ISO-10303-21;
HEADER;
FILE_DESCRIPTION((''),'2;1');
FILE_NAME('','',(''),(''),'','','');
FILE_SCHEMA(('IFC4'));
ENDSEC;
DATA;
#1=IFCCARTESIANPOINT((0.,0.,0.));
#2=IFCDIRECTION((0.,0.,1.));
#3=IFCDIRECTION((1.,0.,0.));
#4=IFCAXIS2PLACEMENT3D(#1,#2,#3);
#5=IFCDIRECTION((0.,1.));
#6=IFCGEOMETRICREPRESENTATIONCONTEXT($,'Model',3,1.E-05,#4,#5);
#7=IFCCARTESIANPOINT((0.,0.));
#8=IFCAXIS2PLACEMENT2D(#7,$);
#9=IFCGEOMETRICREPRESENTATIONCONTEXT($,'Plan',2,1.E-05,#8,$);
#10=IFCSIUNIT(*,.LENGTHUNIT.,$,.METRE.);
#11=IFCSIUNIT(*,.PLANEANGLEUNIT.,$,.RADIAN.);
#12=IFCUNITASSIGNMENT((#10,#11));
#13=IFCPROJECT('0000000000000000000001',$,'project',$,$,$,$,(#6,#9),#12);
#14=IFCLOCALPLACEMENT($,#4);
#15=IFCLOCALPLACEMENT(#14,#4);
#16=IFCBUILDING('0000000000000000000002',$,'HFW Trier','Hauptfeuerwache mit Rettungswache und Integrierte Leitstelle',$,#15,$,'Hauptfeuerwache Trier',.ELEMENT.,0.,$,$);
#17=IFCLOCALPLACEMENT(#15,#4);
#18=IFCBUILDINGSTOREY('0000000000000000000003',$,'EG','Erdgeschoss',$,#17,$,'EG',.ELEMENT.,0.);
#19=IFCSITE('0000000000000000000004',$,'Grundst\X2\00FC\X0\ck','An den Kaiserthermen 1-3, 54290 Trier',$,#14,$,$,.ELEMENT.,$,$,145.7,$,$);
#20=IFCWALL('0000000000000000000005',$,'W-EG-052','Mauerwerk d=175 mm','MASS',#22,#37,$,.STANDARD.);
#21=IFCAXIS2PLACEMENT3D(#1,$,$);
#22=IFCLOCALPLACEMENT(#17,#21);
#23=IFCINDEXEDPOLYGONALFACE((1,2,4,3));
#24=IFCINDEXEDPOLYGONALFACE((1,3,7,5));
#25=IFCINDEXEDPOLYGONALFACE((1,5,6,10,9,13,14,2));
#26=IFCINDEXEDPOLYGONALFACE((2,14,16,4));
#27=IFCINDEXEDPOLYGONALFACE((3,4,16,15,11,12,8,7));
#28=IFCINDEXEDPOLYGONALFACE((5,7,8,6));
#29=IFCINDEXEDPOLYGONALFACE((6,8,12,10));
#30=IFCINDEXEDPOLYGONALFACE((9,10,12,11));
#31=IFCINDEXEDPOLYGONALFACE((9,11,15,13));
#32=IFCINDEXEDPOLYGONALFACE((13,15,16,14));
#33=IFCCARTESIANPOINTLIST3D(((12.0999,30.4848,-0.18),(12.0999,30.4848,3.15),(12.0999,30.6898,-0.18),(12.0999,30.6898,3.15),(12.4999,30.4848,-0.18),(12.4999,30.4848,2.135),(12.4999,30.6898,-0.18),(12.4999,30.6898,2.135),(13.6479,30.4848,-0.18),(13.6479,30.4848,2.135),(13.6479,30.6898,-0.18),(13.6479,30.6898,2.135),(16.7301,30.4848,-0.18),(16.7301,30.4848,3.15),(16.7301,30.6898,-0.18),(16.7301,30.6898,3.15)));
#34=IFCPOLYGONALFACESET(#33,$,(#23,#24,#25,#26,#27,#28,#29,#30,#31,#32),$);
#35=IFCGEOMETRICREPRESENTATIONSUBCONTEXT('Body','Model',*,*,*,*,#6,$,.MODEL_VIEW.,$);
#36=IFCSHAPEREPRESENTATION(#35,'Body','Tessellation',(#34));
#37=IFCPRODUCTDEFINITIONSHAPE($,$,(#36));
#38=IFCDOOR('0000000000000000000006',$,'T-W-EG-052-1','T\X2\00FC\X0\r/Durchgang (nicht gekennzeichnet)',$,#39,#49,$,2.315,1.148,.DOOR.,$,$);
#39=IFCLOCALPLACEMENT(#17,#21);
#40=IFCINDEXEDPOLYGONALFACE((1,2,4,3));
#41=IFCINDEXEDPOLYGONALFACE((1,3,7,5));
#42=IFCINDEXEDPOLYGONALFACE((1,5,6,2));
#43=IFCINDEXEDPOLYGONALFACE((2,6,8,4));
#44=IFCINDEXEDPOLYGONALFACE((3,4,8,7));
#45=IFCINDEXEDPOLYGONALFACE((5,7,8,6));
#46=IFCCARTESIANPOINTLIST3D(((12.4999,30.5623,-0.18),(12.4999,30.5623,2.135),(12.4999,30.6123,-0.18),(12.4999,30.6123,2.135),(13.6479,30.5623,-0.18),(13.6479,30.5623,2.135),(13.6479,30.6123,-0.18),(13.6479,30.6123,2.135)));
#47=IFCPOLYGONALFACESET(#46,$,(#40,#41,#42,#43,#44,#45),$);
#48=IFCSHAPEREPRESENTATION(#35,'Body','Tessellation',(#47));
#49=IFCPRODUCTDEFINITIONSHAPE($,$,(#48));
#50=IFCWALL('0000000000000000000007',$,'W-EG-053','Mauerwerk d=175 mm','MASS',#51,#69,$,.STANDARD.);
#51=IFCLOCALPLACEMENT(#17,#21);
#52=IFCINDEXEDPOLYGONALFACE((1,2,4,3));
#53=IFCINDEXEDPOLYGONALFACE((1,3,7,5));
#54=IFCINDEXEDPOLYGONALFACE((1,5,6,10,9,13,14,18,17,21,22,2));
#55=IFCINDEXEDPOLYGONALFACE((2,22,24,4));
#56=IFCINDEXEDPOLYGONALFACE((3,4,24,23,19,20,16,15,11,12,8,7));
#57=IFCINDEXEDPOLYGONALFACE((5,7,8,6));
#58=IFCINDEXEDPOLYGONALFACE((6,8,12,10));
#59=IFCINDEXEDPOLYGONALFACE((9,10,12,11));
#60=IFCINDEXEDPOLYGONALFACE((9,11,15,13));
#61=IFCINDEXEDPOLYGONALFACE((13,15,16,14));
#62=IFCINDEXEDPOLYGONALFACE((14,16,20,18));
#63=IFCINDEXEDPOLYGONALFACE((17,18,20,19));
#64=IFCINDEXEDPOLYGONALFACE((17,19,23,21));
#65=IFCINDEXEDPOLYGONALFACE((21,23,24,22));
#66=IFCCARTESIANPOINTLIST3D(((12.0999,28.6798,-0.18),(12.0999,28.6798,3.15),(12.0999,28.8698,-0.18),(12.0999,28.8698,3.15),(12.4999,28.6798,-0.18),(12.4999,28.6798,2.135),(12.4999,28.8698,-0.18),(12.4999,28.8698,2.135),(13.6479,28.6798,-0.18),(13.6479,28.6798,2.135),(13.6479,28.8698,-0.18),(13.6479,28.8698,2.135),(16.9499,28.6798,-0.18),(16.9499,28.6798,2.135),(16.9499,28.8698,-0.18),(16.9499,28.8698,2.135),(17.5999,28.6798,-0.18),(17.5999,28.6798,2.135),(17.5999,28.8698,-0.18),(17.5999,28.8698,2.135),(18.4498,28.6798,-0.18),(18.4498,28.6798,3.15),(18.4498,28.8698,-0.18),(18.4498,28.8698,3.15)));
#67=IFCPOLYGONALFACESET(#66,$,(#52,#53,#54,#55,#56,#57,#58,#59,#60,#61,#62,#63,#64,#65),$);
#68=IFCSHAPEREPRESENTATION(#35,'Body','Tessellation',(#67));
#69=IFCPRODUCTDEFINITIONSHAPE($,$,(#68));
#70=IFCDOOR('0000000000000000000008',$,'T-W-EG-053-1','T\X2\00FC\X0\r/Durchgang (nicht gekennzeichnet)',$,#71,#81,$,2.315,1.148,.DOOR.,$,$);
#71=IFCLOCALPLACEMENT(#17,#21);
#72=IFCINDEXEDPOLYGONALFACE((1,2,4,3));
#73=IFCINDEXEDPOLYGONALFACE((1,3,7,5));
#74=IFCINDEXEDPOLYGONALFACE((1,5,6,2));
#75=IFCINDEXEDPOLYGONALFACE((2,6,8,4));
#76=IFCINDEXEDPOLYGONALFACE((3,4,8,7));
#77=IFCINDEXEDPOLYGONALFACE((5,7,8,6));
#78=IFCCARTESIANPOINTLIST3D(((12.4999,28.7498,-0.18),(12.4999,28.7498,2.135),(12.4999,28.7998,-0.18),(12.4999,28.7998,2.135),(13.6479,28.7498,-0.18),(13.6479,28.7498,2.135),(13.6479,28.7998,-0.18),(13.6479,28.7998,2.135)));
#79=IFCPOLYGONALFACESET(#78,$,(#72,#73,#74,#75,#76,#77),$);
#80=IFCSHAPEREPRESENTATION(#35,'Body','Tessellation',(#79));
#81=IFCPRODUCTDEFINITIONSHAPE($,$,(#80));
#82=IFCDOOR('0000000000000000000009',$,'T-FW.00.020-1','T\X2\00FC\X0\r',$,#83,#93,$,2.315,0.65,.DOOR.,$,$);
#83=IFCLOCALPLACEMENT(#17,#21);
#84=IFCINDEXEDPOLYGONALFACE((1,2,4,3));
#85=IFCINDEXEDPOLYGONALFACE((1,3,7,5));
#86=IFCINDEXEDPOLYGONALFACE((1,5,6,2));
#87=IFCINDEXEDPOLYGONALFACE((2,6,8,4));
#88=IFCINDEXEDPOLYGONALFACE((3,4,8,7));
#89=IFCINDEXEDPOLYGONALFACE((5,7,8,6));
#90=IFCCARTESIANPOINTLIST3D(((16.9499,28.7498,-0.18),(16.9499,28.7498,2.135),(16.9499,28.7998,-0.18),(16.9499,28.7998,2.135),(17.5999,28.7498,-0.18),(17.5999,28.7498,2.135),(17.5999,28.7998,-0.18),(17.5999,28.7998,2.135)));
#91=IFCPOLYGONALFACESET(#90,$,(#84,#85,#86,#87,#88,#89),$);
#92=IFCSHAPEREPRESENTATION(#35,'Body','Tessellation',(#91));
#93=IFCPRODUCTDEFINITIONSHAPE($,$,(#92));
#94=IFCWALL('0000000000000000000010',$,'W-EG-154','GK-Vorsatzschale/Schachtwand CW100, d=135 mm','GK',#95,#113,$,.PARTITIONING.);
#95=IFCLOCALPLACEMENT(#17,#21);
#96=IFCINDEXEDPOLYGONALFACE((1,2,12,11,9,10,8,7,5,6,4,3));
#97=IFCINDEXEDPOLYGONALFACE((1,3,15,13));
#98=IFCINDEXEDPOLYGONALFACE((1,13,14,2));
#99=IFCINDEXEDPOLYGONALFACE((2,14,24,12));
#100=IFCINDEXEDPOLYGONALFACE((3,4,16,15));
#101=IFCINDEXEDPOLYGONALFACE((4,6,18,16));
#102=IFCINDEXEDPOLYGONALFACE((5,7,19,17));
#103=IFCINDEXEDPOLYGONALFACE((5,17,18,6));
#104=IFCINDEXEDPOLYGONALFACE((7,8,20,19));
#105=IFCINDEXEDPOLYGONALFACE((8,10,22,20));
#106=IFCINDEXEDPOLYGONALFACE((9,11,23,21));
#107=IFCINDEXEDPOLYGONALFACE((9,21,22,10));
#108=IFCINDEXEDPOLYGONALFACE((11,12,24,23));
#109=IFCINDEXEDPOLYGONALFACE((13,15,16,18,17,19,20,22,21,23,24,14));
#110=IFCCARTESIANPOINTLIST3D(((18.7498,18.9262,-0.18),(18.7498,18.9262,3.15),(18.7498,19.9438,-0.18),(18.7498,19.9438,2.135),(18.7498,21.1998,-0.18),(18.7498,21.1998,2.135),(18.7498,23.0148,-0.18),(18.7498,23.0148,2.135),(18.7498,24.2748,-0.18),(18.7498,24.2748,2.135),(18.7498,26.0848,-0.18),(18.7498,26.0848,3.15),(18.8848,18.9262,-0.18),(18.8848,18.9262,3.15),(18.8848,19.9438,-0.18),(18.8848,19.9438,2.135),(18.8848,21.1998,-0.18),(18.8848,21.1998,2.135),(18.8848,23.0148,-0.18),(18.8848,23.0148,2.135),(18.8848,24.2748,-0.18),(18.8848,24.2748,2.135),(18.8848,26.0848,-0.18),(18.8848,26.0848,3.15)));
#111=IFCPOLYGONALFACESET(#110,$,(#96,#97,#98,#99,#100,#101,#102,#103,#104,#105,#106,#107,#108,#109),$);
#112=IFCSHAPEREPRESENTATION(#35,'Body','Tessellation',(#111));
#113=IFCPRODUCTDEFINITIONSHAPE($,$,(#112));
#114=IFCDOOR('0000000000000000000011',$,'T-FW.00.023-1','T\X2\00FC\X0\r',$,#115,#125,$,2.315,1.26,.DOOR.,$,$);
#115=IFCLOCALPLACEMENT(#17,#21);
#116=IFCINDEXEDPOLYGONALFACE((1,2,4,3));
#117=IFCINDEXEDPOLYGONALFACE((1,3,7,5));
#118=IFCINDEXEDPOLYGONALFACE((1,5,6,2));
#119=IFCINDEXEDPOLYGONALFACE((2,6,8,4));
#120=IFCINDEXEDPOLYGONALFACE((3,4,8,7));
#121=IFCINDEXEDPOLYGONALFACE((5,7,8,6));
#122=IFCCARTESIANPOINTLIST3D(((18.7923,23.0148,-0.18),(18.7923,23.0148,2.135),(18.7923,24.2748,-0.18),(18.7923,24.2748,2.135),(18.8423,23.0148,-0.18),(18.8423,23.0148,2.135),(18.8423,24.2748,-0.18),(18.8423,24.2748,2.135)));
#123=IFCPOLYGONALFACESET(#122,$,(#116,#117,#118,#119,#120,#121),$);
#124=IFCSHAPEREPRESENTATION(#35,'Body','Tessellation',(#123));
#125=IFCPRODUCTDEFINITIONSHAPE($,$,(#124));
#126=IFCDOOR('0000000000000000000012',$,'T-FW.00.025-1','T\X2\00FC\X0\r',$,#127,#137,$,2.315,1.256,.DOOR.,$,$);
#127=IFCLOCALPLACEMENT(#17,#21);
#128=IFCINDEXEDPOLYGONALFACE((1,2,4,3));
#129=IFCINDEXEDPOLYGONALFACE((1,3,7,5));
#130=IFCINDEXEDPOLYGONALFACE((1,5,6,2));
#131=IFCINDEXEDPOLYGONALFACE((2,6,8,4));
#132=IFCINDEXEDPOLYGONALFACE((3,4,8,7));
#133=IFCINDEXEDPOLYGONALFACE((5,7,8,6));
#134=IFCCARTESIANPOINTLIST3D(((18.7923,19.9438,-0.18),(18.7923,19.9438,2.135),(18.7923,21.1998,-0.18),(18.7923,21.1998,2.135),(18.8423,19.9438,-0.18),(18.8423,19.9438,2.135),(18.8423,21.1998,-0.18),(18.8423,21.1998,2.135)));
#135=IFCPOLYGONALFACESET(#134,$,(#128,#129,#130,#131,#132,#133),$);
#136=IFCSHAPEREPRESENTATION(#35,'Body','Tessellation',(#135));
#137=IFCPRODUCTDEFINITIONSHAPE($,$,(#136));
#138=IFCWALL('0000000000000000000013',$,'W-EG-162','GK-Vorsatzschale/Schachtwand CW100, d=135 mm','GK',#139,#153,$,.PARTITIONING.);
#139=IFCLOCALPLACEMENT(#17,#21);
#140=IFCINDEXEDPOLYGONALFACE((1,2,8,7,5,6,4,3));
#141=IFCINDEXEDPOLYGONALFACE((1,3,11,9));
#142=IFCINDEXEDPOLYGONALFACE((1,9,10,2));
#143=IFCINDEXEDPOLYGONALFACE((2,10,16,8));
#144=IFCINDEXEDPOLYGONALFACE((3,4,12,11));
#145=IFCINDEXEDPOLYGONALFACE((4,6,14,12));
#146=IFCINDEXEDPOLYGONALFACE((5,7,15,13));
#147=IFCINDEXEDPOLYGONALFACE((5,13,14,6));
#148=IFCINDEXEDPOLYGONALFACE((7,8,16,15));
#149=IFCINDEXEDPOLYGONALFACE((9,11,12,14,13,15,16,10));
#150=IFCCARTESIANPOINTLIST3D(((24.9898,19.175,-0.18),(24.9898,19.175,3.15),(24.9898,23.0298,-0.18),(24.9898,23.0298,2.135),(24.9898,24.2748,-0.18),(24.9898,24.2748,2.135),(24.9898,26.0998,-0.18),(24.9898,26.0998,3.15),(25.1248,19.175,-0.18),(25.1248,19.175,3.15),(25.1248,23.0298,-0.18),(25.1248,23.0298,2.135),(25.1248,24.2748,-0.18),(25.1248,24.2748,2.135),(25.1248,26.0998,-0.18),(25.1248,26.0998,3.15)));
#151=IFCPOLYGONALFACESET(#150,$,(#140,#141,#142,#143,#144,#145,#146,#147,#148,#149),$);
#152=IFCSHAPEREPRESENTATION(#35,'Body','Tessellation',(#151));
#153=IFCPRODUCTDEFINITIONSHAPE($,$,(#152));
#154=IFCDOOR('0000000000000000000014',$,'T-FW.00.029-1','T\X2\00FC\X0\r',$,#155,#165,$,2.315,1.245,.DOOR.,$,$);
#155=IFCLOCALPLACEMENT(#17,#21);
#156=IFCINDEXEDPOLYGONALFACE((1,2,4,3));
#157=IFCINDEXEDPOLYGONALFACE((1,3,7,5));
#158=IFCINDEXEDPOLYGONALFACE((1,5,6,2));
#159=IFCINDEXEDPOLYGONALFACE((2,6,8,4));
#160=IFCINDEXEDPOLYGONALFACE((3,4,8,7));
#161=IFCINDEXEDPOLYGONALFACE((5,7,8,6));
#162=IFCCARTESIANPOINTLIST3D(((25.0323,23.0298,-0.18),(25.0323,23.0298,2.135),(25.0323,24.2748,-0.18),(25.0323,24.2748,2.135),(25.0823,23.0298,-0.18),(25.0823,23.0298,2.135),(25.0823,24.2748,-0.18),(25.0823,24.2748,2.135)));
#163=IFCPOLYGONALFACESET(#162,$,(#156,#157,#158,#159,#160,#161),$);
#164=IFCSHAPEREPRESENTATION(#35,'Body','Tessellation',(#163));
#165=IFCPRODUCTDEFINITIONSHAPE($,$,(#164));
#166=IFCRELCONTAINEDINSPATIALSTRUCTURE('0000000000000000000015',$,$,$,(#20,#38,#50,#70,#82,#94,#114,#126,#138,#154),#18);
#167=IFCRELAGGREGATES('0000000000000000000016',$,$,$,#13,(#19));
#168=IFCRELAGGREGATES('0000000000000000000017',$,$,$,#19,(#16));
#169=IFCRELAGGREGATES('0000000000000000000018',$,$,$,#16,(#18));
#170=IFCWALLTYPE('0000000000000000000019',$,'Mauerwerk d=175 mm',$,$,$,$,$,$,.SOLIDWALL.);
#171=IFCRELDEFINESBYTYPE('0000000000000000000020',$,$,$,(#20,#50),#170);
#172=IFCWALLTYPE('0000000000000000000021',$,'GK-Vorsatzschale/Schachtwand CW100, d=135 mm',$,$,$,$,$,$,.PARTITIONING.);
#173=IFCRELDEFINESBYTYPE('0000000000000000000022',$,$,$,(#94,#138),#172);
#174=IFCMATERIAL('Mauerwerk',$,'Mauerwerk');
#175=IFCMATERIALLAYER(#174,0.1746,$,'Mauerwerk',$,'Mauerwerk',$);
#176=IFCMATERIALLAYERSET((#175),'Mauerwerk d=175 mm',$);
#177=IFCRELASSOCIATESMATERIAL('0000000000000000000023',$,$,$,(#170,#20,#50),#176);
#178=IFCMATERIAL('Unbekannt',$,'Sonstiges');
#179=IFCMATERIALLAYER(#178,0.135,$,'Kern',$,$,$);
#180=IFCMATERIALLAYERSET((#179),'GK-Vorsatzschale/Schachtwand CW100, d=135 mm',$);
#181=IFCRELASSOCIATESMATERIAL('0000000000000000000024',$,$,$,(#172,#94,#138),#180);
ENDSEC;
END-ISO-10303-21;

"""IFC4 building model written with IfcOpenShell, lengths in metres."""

from ifc_helpers import new_model, si_unit, direction, frame, frame_2d, origin_with_axes, origin_2d, place, context, subcontext, project, spatial, rectangle, extrude, material, layer, layer_set, layer_usage, type_object, element, fill, save


model = new_model("IFC4")

# Units and contexts
model_context = context("Model", 3, precision=1e-05, world=origin_with_axes(), true_north=direction((0.0, 1.0)))
plan_context = context("Plan", 2, precision=1e-05, world=origin_2d())
body_context = subcontext(model_context, "Body", "Model", "MODEL_VIEW")
ifc_project = project(units=[si_unit("LENGTHUNIT", "METRE"), si_unit("PLANEANGLEUNIT", "RADIAN")], contexts=[model_context, plan_context])

# Site, building, storey
site_placement = place(None, origin_with_axes())
site = spatial("IfcSite", under=ifc_project, at=site_placement, Name="Grundstück", Description="An den Kaiserthermen 1-3, 54290 Trier", CompositionType="ELEMENT", RefElevation=145.7)
building_placement = place(site_placement, origin_with_axes())
building = spatial("IfcBuilding", under=site, at=building_placement, Name="HFW Trier", Description="Hauptfeuerwache mit Rettungswache und Integrierte Leitstelle", LongName="Hauptfeuerwache Trier", CompositionType="ELEMENT", ElevationOfRefHeight=0.0)
storey_placement = place(building_placement, origin_with_axes())
storey = spatial("IfcBuildingStorey", under=building, at=storey_placement, Name="EG", Description="Erdgeschoss", LongName="EG", CompositionType="ELEMENT", Elevation=0.0)

# Wall, opening, door
ifc_material_1 = material(Name="Mauerwerk", Category="Mauerwerk")
ifc_layer_1 = layer(ifc_material_1, 0.1746, Name="Mauerwerk", Category="Mauerwerk")
ifc_layer_set_1 = layer_set([ifc_layer_1], Name="Mauerwerk d=175 mm")
ifc_layer_usage_1 = layer_usage(ifc_layer_set_1, "AXIS2", "POSITIVE", -0.1025)
wall_type_1 = type_object("IfcWallType", Name="Mauerwerk d=175 mm", PredefinedType="SOLIDWALL", material=ifc_layer_set_1)
wall_1_placement = place(storey_placement, frame((12.0999, 30.5873, -0.18), z_axis=(0.0, 0.0, 1.0), x_axis=(1.0, 0.0, 0.0)))
wall_1 = element("IfcWall", 1, at=wall_1_placement, inside=storey, type_object=wall_type_1, material=ifc_layer_usage_1, Name="W-EG-052", Description="Mauerwerk d=175 mm", ObjectType="MASS", PredefinedType="STANDARD", context=body_context, shape_type="SweptSolid", body=[
    extrude(rectangle(XDim=4.6302, YDim=0.205, at=frame_2d((2.3151, 0.0))), origin_with_axes(), (0.0, 0.0, 1.0), 3.33),
])
opening_1_placement = place(wall_1_placement, frame((0.4, 0.0, 0.0), z_axis=(0.0, 0.0, 1.0), x_axis=(1.0, 0.0, 0.0)))
opening_1 = element("IfcOpeningElement", 2, at=opening_1_placement, cuts=wall_1, PredefinedType="OPENING", context=body_context, shape_type="SweptSolid", body=[
    extrude(rectangle(XDim=1.148, YDim=0.305, at=frame_2d((0.574, 0.0))), origin_with_axes(), (0.0, 0.0, 1.0), 2.315),
])
door_1_placement = place(wall_1_placement, frame((0.4, 0.0, 0.0), z_axis=(0.0, 0.0, 1.0), x_axis=(1.0, 0.0, 0.0)))
door_1 = element("IfcDoor", 3, at=door_1_placement, inside=storey, Name="T-W-EG-052-1", Description="Tür/Durchgang (nicht gekennzeichnet)", OverallHeight=2.315, OverallWidth=1.148, PredefinedType="DOOR", context=body_context, shape_type="SweptSolid", body=[
    extrude(rectangle(XDim=1.148, YDim=0.05, at=frame_2d((0.574, 0.0))), origin_with_axes(), (0.0, 0.0, 1.0), 2.315),
])
fill(opening_1, door_1)

# Walls, openings, doors
ifc_layer_usage_2 = layer_usage(ifc_layer_set_1, "AXIS2", "POSITIVE", -0.095)
wall_2_placement = place(storey_placement, frame((12.0999, 28.7748, -0.18), z_axis=(0.0, 0.0, 1.0), x_axis=(1.0, 0.0, 0.0)))
wall_2 = element("IfcWall", 4, at=wall_2_placement, inside=storey, type_object=wall_type_1, material=ifc_layer_usage_2, Name="W-EG-053", Description="Mauerwerk d=175 mm", ObjectType="MASS", PredefinedType="STANDARD", context=body_context, shape_type="SweptSolid", body=[
    extrude(rectangle(XDim=6.3499, YDim=0.19, at=frame_2d((3.1749, 0.0))), origin_with_axes(), (0.0, 0.0, 1.0), 3.33),
])
opening_2_placement = place(wall_2_placement, frame((0.4, 0.0, 0.0), z_axis=(0.0, 0.0, 1.0), x_axis=(1.0, 0.0, 0.0)))
opening_2 = element("IfcOpeningElement", 5, at=opening_2_placement, cuts=wall_2, PredefinedType="OPENING", context=body_context, shape_type="SweptSolid", body=[
    extrude(rectangle(XDim=1.148, YDim=0.29, at=frame_2d((0.574, 0.0))), origin_with_axes(), (0.0, 0.0, 1.0), 2.315),
])
opening_3_placement = place(wall_2_placement, frame((4.85, 0.0, 0.0), z_axis=(0.0, 0.0, 1.0), x_axis=(1.0, 0.0, 0.0)))
opening_3 = element("IfcOpeningElement", 6, at=opening_3_placement, cuts=wall_2, PredefinedType="OPENING", context=body_context, shape_type="SweptSolid", body=[
    extrude(rectangle(XDim=0.65, YDim=0.29, at=frame_2d((0.325, 0.0))), origin_with_axes(), (0.0, 0.0, 1.0), 2.315),
])
door_2_placement = place(wall_2_placement, frame((0.4, 0.0, 0.0), z_axis=(0.0, 0.0, 1.0), x_axis=(1.0, 0.0, 0.0)))
door_2 = element("IfcDoor", 7, at=door_2_placement, inside=storey, Name="T-W-EG-053-1", Description="Tür/Durchgang (nicht gekennzeichnet)", OverallHeight=2.315, OverallWidth=1.148, PredefinedType="DOOR", context=body_context, shape_type="SweptSolid", body=[
    extrude(rectangle(XDim=1.148, YDim=0.05, at=frame_2d((0.574, 0.0))), origin_with_axes(), (0.0, 0.0, 1.0), 2.315),
])
fill(opening_2, door_2)
door_3_placement = place(wall_2_placement, frame((4.85, 0.0, 0.0), z_axis=(0.0, 0.0, 1.0), x_axis=(1.0, 0.0, 0.0)))
door_3 = element("IfcDoor", 8, at=door_3_placement, inside=storey, Name="T-FW.00.020-1", Description="Tür", OverallHeight=2.315, OverallWidth=0.65, PredefinedType="DOOR", context=body_context, shape_type="SweptSolid", body=[
    extrude(rectangle(XDim=0.65, YDim=0.05, at=frame_2d((0.325, 0.0))), origin_with_axes(), (0.0, 0.0, 1.0), 2.315),
])
fill(opening_3, door_3)
ifc_material_2 = material(Name="Unbekannt", Category="Sonstiges")
ifc_layer_2 = layer(ifc_material_2, 0.135, Name="Kern")
ifc_layer_set_2 = layer_set([ifc_layer_2], Name="GK-Vorsatzschale/Schachtwand CW100, d=135 mm")
ifc_layer_usage_3 = layer_usage(ifc_layer_set_2, "AXIS2", "POSITIVE", -0.0675)
wall_type_2 = type_object("IfcWallType", Name="GK-Vorsatzschale/Schachtwand CW100, d=135 mm", PredefinedType="PARTITIONING", material=ifc_layer_set_2)
wall_3_placement = place(storey_placement, frame((18.8173, 26.0848, -0.18), z_axis=(0.0, 0.0, 1.0), x_axis=(0.0, -1.0, 0.0)))
wall_3 = element("IfcWall", 9, at=wall_3_placement, inside=storey, type_object=wall_type_2, material=ifc_layer_usage_3, Name="W-EG-154", Description="GK-Vorsatzschale/Schachtwand CW100, d=135 mm", ObjectType="GK", PredefinedType="PARTITIONING", context=body_context, shape_type="SweptSolid", body=[
    extrude(rectangle(XDim=7.1586, YDim=0.135, at=frame_2d((3.5793, 0.0))), origin_with_axes(), (0.0, 0.0, 1.0), 3.33),
])
opening_4_placement = place(wall_3_placement, frame((1.81, 0.0, 0.0), z_axis=(0.0, 0.0, 1.0), x_axis=(1.0, 0.0, 0.0)))
opening_4 = element("IfcOpeningElement", 10, at=opening_4_placement, cuts=wall_3, PredefinedType="OPENING", context=body_context, shape_type="SweptSolid", body=[
    extrude(rectangle(XDim=1.26, YDim=0.235, at=frame_2d((0.63, 0.0))), origin_with_axes(), (0.0, 0.0, 1.0), 2.315),
])
opening_5_placement = place(wall_3_placement, frame((4.885, 0.0, 0.0), z_axis=(0.0, 0.0, 1.0), x_axis=(1.0, 0.0, 0.0)))
opening_5 = element("IfcOpeningElement", 11, at=opening_5_placement, cuts=wall_3, PredefinedType="OPENING", context=body_context, shape_type="SweptSolid", body=[
    extrude(rectangle(XDim=1.256, YDim=0.235, at=frame_2d((0.628, 0.0))), origin_with_axes(), (0.0, 0.0, 1.0), 2.315),
])
door_4_placement = place(wall_3_placement, frame((1.81, 0.0, 0.0), z_axis=(0.0, 0.0, 1.0), x_axis=(1.0, 0.0, 0.0)))
door_4 = element("IfcDoor", 12, at=door_4_placement, inside=storey, Name="T-FW.00.023-1", Description="Tür", OverallHeight=2.315, OverallWidth=1.26, PredefinedType="DOOR", context=body_context, shape_type="SweptSolid", body=[
    extrude(rectangle(XDim=1.26, YDim=0.05, at=frame_2d((0.63, 0.0))), origin_with_axes(), (0.0, 0.0, 1.0), 2.315),
])
fill(opening_4, door_4)
door_5_placement = place(wall_3_placement, frame((4.885, 0.0, 0.0), z_axis=(0.0, 0.0, 1.0), x_axis=(1.0, 0.0, 0.0)))
door_5 = element("IfcDoor", 13, at=door_5_placement, inside=storey, Name="T-FW.00.025-1", Description="Tür", OverallHeight=2.315, OverallWidth=1.256, PredefinedType="DOOR", context=body_context, shape_type="SweptSolid", body=[
    extrude(rectangle(XDim=1.256, YDim=0.05, at=frame_2d((0.628, 0.0))), origin_with_axes(), (0.0, 0.0, 1.0), 2.315),
])
fill(opening_5, door_5)

# Wall, opening, door
ifc_layer_usage_4 = layer_usage(ifc_layer_set_2, "AXIS2", "POSITIVE", -0.0675)
wall_4_placement = place(storey_placement, frame((25.0573, 26.0998, -0.18), z_axis=(0.0, 0.0, 1.0), x_axis=(0.0, -1.0, 0.0)))
wall_4 = element("IfcWall", 14, at=wall_4_placement, inside=storey, type_object=wall_type_2, material=ifc_layer_usage_4, Name="W-EG-162", Description="GK-Vorsatzschale/Schachtwand CW100, d=135 mm", ObjectType="GK", PredefinedType="PARTITIONING", context=body_context, shape_type="SweptSolid", body=[
    extrude(rectangle(XDim=6.9248, YDim=0.135, at=frame_2d((3.4624, 0.0))), origin_with_axes(), (0.0, 0.0, 1.0), 3.33),
])
opening_6_placement = place(wall_4_placement, frame((1.825, 0.0, 0.0), z_axis=(0.0, 0.0, 1.0), x_axis=(1.0, 0.0, 0.0)))
opening_6 = element("IfcOpeningElement", 15, at=opening_6_placement, cuts=wall_4, PredefinedType="OPENING", context=body_context, shape_type="SweptSolid", body=[
    extrude(rectangle(XDim=1.245, YDim=0.235, at=frame_2d((0.6225, 0.0))), origin_with_axes(), (0.0, 0.0, 1.0), 2.315),
])
door_6_placement = place(wall_4_placement, frame((1.825, 0.0, 0.0), z_axis=(0.0, 0.0, 1.0), x_axis=(1.0, 0.0, 0.0)))
door_6 = element("IfcDoor", 16, at=door_6_placement, inside=storey, Name="T-FW.00.029-1", Description="Tür", OverallHeight=2.315, OverallWidth=1.245, PredefinedType="DOOR", context=body_context, shape_type="SweptSolid", body=[
    extrude(rectangle(XDim=1.245, YDim=0.05, at=frame_2d((0.6225, 0.0))), origin_with_axes(), (0.0, 0.0, 1.0), 2.315),
])
fill(opening_6, door_6)

save(model, "model.ifc")
